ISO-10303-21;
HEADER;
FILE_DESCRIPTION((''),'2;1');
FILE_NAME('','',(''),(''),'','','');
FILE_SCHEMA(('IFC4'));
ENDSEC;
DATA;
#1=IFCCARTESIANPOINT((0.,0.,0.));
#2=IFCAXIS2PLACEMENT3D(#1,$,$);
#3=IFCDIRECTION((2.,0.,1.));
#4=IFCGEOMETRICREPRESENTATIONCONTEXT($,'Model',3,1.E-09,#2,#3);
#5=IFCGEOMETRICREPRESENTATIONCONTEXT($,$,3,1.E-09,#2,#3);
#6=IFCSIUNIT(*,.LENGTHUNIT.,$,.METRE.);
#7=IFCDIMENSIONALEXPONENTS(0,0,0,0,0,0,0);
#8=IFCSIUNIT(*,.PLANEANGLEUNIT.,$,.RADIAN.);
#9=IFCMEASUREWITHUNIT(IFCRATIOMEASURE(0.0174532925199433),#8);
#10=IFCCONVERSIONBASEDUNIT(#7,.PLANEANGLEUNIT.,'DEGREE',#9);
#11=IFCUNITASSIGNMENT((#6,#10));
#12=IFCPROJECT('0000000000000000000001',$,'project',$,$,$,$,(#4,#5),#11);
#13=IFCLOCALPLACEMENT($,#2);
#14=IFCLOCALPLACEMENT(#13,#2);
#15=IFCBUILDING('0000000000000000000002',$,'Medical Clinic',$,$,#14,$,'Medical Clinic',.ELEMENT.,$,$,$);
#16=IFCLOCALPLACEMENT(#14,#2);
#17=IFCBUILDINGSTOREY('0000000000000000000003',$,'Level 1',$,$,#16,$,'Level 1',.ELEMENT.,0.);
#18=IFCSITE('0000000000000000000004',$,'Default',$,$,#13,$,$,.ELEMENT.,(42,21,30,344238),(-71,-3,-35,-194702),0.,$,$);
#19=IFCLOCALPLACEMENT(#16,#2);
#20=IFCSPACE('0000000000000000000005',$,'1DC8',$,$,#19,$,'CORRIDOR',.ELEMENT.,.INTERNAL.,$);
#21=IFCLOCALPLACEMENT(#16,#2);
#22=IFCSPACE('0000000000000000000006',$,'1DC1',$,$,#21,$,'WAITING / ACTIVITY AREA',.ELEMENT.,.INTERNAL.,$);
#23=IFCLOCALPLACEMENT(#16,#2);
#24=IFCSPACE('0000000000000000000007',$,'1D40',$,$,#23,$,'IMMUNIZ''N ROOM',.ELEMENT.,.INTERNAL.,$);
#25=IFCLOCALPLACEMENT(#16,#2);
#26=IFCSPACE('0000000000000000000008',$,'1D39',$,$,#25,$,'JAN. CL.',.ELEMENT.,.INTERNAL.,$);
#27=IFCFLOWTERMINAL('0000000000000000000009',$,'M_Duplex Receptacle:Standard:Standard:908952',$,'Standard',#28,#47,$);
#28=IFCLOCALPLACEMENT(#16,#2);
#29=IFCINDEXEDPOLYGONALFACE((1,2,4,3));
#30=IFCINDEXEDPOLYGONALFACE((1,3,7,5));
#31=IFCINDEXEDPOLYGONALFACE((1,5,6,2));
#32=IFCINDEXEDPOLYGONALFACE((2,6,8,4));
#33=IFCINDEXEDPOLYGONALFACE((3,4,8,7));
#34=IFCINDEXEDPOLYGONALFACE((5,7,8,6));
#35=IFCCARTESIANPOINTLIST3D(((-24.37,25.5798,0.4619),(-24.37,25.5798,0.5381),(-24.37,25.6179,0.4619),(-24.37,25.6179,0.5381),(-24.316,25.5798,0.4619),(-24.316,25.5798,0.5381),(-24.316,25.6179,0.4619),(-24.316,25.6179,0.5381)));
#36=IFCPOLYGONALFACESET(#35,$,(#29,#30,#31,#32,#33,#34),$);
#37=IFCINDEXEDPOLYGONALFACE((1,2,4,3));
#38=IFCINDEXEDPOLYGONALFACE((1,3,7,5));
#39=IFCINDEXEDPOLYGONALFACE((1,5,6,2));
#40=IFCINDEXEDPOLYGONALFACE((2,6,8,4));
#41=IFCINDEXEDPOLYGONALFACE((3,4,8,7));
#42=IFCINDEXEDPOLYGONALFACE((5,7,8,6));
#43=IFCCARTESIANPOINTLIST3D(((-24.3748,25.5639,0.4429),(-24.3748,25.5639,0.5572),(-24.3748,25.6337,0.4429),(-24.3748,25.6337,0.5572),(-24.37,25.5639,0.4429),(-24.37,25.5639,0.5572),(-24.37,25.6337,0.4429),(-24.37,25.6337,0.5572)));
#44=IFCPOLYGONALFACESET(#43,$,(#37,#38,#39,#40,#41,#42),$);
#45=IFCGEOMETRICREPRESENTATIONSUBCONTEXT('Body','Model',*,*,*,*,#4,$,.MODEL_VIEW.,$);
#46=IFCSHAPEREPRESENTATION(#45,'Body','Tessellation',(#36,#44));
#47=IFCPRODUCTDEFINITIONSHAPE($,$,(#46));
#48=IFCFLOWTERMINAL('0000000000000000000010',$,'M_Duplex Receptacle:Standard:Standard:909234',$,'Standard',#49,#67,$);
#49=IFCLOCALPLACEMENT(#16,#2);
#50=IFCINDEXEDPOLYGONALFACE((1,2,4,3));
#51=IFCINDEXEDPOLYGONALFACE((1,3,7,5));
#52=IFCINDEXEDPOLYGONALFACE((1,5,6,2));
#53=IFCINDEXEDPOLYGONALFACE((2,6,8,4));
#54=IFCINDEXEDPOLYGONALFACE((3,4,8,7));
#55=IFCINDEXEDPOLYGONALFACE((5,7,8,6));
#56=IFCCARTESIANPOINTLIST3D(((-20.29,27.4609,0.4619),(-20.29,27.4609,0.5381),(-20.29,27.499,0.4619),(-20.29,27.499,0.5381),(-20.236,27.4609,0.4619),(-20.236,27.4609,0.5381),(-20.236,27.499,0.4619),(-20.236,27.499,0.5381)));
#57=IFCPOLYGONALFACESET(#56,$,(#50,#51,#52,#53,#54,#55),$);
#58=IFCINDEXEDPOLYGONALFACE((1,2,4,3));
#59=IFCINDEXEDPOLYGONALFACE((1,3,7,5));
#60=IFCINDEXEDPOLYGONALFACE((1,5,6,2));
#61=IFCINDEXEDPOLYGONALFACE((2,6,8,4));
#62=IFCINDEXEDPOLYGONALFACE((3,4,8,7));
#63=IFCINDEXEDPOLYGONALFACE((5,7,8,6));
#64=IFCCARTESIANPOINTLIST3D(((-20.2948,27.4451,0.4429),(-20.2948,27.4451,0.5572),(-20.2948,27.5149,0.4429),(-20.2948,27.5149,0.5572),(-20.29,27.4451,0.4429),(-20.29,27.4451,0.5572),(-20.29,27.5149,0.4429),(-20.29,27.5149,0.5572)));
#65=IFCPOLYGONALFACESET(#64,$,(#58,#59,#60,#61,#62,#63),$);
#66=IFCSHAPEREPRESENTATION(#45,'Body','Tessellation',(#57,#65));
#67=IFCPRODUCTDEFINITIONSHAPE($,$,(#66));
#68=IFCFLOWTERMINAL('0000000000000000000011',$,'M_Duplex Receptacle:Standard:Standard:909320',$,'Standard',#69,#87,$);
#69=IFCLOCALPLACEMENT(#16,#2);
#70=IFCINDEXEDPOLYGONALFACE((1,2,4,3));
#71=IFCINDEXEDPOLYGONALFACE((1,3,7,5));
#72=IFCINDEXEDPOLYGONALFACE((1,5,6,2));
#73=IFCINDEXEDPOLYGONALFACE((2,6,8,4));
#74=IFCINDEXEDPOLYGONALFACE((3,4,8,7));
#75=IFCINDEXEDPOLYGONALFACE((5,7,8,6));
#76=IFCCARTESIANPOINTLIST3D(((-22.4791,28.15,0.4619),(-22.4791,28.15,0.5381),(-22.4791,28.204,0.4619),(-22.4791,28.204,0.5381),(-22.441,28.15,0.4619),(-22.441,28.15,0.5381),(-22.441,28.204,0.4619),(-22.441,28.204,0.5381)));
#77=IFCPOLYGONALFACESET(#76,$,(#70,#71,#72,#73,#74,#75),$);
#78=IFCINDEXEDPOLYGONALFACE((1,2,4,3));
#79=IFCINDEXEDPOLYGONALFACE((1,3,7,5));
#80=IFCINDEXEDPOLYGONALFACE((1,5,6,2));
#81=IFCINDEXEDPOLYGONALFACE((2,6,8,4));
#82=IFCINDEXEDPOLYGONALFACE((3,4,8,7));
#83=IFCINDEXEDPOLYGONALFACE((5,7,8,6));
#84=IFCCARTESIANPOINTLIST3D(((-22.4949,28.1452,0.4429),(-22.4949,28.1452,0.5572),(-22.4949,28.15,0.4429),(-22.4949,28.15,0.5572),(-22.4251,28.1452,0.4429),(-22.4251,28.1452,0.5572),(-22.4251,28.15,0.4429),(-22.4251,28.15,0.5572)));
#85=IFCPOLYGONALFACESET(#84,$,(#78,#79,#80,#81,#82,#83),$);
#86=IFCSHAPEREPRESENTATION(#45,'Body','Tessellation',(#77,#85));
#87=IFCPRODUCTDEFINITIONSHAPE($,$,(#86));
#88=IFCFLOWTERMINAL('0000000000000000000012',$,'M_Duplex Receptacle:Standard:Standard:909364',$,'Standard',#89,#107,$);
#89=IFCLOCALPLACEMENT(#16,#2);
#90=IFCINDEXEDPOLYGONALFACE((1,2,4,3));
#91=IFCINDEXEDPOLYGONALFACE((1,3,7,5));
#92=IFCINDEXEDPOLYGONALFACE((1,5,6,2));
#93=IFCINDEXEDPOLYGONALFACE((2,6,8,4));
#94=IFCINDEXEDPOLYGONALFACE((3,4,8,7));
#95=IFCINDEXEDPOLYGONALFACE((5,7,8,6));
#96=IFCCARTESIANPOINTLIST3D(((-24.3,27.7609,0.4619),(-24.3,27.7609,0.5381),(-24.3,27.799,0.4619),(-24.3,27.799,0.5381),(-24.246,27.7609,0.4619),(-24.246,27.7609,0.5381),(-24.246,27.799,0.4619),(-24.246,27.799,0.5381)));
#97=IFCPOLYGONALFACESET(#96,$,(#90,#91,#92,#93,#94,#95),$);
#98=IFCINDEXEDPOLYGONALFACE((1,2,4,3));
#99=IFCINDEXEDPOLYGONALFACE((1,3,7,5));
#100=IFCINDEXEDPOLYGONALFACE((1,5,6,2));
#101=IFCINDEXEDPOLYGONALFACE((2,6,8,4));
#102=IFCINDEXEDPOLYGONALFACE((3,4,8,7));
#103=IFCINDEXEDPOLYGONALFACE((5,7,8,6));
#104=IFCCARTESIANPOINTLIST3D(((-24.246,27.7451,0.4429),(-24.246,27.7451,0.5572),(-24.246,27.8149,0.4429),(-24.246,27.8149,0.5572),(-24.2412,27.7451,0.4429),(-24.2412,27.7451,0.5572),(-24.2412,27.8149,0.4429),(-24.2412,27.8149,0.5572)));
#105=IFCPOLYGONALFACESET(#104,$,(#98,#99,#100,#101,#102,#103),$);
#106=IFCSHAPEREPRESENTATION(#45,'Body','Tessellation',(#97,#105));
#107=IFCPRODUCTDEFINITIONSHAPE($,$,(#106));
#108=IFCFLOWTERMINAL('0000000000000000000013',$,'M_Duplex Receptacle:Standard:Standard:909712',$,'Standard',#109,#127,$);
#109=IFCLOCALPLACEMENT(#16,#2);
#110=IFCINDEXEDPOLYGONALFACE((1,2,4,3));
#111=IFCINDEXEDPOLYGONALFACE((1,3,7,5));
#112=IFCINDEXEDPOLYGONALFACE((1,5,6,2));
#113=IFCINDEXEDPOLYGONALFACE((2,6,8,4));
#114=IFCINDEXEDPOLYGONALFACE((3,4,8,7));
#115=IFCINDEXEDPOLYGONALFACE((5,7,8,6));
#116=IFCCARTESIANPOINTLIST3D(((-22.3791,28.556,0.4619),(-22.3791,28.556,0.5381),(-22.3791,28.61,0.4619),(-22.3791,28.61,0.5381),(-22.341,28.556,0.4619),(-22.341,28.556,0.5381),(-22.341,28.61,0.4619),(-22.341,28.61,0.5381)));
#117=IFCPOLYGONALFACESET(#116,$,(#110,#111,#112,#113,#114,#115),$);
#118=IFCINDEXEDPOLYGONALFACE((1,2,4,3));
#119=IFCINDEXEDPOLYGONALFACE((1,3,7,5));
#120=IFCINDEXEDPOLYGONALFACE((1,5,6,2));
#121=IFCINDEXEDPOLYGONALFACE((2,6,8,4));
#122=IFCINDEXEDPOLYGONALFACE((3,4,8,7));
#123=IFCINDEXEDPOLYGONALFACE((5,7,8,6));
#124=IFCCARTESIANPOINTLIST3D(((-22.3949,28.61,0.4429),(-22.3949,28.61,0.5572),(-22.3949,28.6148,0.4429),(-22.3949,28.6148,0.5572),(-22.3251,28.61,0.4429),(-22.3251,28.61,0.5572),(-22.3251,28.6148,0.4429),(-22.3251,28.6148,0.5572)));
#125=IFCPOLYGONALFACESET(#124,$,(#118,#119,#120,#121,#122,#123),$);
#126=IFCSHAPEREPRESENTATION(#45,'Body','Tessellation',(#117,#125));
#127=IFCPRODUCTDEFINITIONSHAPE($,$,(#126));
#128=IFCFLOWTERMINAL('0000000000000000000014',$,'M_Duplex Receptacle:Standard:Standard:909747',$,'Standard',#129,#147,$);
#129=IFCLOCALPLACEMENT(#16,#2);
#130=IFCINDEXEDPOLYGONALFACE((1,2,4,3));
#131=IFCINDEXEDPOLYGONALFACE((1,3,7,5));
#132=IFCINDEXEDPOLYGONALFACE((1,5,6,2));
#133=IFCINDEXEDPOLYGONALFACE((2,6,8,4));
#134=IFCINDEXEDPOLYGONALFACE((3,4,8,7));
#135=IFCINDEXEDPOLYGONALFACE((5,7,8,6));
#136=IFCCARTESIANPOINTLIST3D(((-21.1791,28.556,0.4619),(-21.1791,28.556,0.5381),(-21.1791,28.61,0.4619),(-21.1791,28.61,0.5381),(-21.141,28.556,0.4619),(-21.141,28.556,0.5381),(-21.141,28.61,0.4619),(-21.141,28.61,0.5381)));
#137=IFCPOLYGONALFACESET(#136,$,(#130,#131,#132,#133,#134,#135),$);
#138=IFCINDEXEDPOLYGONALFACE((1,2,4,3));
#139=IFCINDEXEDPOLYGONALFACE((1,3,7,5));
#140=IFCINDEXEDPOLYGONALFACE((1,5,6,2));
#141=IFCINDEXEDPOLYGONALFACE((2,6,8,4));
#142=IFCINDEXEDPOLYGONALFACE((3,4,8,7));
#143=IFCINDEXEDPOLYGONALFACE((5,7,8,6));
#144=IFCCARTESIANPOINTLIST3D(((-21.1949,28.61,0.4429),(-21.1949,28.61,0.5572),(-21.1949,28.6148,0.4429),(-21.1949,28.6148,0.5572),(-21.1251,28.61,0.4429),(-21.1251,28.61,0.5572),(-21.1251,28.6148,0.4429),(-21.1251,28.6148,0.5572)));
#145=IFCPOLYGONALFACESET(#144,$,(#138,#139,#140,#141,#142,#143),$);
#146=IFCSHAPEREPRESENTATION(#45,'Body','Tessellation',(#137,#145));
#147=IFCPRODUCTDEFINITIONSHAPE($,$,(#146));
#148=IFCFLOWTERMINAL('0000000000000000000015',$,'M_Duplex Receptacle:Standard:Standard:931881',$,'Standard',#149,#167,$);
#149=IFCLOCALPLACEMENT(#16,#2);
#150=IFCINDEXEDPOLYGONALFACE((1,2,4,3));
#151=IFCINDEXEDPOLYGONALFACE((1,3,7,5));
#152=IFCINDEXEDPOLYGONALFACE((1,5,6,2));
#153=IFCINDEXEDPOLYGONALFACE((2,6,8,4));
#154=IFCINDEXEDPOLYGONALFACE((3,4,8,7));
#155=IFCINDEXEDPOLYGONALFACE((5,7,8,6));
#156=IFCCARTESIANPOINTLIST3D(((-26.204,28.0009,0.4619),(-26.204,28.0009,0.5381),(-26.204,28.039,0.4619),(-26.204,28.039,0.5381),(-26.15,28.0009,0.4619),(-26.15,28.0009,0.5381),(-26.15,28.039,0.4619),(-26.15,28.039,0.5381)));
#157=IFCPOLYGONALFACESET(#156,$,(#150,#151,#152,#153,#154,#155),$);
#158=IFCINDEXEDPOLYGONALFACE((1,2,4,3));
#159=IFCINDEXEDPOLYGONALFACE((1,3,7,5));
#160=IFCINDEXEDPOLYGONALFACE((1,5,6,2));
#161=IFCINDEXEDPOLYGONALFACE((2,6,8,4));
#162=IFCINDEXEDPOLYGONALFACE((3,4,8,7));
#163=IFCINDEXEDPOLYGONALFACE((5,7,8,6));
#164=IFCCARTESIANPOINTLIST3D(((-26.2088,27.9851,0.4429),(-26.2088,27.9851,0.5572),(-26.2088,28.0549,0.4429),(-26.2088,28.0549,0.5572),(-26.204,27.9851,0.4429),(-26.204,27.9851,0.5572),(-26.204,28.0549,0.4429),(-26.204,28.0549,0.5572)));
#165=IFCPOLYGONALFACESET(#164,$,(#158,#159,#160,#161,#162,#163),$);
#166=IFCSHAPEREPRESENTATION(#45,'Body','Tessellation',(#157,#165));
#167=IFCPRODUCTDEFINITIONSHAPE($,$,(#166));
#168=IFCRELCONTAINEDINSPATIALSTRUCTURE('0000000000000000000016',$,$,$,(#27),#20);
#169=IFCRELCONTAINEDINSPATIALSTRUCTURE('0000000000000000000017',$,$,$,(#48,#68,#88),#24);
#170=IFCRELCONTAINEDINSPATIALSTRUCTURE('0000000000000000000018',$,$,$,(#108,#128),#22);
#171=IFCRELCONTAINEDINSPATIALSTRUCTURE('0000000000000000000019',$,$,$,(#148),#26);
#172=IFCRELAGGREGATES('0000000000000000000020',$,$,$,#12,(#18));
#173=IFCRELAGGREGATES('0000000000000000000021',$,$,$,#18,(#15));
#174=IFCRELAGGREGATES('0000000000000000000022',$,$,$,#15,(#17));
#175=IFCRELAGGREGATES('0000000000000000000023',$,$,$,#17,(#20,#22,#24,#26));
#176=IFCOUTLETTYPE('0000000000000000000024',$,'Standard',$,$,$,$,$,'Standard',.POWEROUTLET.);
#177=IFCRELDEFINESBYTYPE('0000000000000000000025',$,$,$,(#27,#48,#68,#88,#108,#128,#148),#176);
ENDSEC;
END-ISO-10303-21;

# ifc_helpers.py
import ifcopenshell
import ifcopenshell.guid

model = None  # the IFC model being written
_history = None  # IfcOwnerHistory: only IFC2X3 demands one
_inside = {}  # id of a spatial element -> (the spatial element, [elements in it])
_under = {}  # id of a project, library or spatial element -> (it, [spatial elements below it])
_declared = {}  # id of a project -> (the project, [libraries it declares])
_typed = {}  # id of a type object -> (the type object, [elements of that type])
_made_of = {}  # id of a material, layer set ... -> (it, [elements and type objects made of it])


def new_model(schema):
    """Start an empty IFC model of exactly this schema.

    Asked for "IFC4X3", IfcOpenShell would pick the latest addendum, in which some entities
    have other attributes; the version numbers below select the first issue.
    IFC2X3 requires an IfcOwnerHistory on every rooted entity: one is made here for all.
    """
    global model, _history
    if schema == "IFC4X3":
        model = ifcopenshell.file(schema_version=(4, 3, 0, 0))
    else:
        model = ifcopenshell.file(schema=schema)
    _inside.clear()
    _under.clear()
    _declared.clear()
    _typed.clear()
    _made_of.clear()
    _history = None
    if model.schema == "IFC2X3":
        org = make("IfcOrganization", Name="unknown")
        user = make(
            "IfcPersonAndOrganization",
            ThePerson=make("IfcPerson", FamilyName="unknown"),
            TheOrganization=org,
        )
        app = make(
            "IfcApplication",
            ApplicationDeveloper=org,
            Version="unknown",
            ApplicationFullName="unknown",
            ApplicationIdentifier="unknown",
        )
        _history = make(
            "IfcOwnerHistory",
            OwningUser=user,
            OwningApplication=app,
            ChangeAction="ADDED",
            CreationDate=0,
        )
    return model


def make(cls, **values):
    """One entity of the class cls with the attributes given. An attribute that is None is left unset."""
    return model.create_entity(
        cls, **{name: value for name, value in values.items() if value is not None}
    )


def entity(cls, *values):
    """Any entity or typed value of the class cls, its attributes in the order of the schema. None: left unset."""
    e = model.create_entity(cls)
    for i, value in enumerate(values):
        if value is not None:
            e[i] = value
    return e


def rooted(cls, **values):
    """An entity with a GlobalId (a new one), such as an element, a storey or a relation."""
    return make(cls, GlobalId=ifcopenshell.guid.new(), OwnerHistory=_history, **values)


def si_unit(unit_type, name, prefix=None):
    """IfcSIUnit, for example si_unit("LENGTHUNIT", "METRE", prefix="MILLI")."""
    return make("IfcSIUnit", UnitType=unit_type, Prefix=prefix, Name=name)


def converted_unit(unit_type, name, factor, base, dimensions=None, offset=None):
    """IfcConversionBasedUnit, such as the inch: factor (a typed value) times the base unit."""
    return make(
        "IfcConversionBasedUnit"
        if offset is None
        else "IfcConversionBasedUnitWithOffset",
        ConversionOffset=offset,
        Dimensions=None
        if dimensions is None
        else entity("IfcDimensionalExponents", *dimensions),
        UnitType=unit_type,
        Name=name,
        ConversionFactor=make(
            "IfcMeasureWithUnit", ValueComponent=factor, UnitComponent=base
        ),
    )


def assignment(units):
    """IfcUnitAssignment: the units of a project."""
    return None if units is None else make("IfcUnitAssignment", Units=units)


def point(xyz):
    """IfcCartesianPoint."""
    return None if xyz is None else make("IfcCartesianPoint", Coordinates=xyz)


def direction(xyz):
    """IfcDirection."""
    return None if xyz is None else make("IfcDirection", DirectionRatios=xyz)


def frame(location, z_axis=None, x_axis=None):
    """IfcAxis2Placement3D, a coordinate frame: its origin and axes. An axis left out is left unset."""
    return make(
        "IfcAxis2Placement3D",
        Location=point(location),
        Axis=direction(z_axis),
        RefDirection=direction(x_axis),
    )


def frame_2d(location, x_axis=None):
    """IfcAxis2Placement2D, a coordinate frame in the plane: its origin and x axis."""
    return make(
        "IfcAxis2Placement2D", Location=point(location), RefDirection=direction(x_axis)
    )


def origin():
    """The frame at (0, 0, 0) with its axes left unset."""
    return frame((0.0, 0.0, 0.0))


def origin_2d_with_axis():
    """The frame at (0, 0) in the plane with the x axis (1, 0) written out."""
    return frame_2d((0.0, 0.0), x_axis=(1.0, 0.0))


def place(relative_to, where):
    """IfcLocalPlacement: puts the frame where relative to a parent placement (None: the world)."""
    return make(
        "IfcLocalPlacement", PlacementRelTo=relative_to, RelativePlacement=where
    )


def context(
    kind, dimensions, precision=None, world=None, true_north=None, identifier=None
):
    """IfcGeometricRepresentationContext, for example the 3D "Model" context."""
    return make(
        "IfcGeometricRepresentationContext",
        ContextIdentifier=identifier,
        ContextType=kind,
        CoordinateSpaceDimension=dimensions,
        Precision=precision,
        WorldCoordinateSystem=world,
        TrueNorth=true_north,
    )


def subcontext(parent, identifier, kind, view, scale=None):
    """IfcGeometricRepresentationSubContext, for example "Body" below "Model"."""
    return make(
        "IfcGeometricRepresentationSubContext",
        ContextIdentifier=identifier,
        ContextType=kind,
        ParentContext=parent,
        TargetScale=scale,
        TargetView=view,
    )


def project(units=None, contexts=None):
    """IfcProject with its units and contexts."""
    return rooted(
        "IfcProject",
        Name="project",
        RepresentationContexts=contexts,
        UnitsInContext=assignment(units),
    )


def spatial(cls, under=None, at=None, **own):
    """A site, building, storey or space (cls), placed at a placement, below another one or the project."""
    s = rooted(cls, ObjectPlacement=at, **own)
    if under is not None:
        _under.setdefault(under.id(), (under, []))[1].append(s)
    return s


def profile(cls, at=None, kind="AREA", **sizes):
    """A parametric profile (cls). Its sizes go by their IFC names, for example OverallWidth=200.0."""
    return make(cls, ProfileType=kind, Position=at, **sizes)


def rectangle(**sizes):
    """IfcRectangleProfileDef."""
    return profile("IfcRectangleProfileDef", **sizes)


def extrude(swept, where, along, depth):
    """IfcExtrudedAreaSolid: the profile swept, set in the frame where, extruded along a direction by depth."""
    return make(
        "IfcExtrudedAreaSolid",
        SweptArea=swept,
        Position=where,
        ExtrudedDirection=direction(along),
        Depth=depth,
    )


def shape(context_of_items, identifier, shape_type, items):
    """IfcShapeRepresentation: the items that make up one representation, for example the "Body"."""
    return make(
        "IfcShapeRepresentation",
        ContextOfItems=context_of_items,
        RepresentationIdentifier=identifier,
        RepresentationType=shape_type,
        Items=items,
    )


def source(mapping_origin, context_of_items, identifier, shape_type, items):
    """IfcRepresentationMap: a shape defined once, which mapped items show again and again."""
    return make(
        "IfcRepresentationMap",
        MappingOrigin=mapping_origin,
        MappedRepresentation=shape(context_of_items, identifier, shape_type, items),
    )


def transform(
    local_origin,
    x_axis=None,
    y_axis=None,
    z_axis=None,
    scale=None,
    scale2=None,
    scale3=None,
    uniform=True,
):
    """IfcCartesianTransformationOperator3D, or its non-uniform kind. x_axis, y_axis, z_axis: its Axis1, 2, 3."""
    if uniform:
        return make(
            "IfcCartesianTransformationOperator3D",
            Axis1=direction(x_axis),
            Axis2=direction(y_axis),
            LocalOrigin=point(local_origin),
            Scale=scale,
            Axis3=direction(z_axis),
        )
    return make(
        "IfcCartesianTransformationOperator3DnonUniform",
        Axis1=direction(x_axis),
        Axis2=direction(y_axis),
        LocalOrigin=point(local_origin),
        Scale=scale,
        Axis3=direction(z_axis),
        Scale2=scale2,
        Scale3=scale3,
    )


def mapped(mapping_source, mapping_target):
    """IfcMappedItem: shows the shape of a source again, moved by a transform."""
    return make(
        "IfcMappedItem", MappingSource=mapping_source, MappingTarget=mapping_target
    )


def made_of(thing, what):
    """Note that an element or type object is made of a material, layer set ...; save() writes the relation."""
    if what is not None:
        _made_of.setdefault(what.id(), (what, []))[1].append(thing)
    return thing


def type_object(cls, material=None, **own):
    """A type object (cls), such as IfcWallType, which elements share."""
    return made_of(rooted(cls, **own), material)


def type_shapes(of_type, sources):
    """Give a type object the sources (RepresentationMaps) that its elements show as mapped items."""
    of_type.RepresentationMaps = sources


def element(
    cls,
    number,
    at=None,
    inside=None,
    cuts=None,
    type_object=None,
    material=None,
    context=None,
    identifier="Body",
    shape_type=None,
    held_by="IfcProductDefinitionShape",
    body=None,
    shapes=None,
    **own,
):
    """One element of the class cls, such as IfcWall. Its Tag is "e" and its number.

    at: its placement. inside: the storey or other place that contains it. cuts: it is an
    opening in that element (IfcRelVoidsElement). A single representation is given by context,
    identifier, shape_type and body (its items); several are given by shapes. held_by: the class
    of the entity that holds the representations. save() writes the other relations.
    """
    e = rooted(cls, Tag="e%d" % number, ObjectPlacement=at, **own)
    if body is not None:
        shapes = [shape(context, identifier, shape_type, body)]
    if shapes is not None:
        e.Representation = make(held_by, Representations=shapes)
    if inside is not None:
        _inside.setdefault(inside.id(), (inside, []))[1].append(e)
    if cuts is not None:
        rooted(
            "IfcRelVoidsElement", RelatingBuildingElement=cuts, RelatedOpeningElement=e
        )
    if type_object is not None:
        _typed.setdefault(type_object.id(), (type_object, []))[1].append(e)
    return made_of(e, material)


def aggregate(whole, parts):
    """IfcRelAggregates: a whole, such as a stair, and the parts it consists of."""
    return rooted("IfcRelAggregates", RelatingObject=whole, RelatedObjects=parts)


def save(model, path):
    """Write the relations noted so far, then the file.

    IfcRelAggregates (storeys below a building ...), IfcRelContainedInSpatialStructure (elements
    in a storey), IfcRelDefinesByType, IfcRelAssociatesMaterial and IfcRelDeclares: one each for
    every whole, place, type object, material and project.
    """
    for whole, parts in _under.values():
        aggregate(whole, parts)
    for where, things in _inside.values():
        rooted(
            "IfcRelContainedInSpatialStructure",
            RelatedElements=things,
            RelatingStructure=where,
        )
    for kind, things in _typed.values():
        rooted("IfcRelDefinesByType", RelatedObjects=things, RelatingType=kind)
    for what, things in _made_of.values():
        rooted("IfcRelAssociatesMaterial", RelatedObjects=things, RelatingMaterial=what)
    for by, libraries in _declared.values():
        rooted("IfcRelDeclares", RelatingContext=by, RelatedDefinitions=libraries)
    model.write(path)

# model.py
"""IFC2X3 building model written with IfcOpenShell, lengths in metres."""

from ifc_helpers import new_model, entity, si_unit, converted_unit, direction, frame, frame_2d, origin, origin_2d_with_axis, place, context, subcontext, project, spatial, rectangle, extrude, source, transform, mapped, type_object, type_shapes, element, save


model = new_model("IFC2X3")

# Units and contexts
model_context = context("Model", 3, precision=1e-09, world=origin(), true_north=direction((2.0, 0.0, 1.0)))
context_of_model = context(None, 3, precision=1e-09, world=origin(), true_north=direction((2.0, 0.0, 1.0)))
body_context = subcontext(model_context, "Body", "Model", "MODEL_VIEW")
ifc_project = project(units=[si_unit("LENGTHUNIT", "METRE"), converted_unit("PLANEANGLEUNIT", "DEGREE", entity("IfcRatioMeasure", 0.0174532925199433), si_unit("PLANEANGLEUNIT", "RADIAN"), dimensions=[0, 0, 0, 0, 0, 0, 0])], contexts=[model_context, context_of_model])

# Site, building, storey
site_placement = place(None, origin())
site = spatial("IfcSite", under=ifc_project, at=site_placement, Name="Default", CompositionType="ELEMENT", RefLatitude=(42, 21, 30, 344238), RefLongitude=(-71, -3, -35, -194702), RefElevation=0.0)
building_placement = place(site_placement, origin())
building = spatial("IfcBuilding", under=site, at=building_placement, Name="Medical Clinic", LongName="Medical Clinic", CompositionType="ELEMENT")
storey_placement = place(building_placement, origin())
storey = spatial("IfcBuildingStorey", under=building, at=storey_placement, Name="Level 1", LongName="Level 1", CompositionType="ELEMENT", Elevation=0.0)

# Shared definitions
space_1_placement = place(storey_placement, origin())
space_1 = spatial("IfcSpace", under=storey, at=space_1_placement, Name="1DC8", LongName="CORRIDOR", CompositionType="ELEMENT", InteriorOrExteriorSpace="INTERNAL")

# Shared definitions
space_2_placement = place(storey_placement, origin())
space_2 = spatial("IfcSpace", under=storey, at=space_2_placement, Name="1DC1", LongName="WAITING / ACTIVITY AREA", CompositionType="ELEMENT", InteriorOrExteriorSpace="INTERNAL")

# Shared definitions
space_3_placement = place(storey_placement, origin())
space_3 = spatial("IfcSpace", under=storey, at=space_3_placement, Name="1D40", LongName="IMMUNIZ'N ROOM", CompositionType="ELEMENT", InteriorOrExteriorSpace="INTERNAL")

# Shared definitions
outlet_type = type_object("IfcOutletType", Name="Standard", ElementType="Standard", PredefinedType="POWEROUTLET")
shared_shape_1 = source(origin(), body_context, "Body", "SweptSolid", [
    extrude(rectangle(XDim=0.0381, YDim=0.0762, at=origin_2d_with_axis()), frame((0.0, 0.0, -0.054), z_axis=(0.0, 0.0, 1.0), x_axis=(-1.0, 0.0, 0.0)), (0.0, 0.0, 1.0), 0.054),
    extrude(rectangle(XDim=0.0698, YDim=0.1143, at=frame_2d((0.0, 0.0), x_axis=(1.0, 0.0))), frame((0.0, 0.0, 0.0), z_axis=(0.0, 0.0, 1.0), x_axis=(-1.0, 0.0, 0.0)), (0.0, 0.0, 1.0), 0.0048),
])
type_shapes(outlet_type, [shared_shape_1])

# Flow terminals
flow_terminal_1_placement = place(space_1_placement, frame((-24.37, 25.5988, 0.5), z_axis=(-1.0, 0.0, 0.0), x_axis=(0.0, -1.0, 0.0)))
element("IfcFlowTerminal", 1, at=flow_terminal_1_placement, inside=space_1, type_object=outlet_type, Name="M_Duplex Receptacle:Standard:Standard:908952", ObjectType="Standard", context=body_context, shape_type="MappedRepresentation", body=[
    mapped(shared_shape_1, transform((0.0, 0.0, 0.0), scale=1.0)),
])
for number, where, z_axis, x_axis, name in (
    (2, (-20.29, 27.48, 0.5), (-1.0, 0.0, 0.0), (0.0, -1.0, 0.0), "M_Duplex Receptacle:Standard:Standard:909234"),
    (3, (-22.46, 28.15, 0.5), (0.0, -1.0, 0.0), (1.0, 0.0, 0.0), "M_Duplex Receptacle:Standard:Standard:909320"),
    (4, (-24.246, 27.78, 0.5), (1.0, 0.0, 0.0), (0.0, 1.0, 0.0), "M_Duplex Receptacle:Standard:Standard:909364"),
):
    element("IfcFlowTerminal", number, at=place(space_3_placement, frame(where, z_axis=z_axis, x_axis=x_axis)), inside=space_3, type_object=outlet_type, Name=name, ObjectType="Standard", context=body_context, shape_type="MappedRepresentation", body=[
        mapped(shared_shape_1, transform((0.0, 0.0, 0.0), scale=1.0)),
    ])
for number, where, z_axis, x_axis, name in (
    (5, (-22.36, 28.61, 0.5), (0.0, 1.0, 0.0), (-1.0, 0.0, 0.0), "M_Duplex Receptacle:Standard:Standard:909712"),
    (6, (-21.16, 28.61, 0.5), (0.0, 1.0, 0.0), (-1.0, 0.0, 0.0), "M_Duplex Receptacle:Standard:Standard:909747"),
):
    element("IfcFlowTerminal", number, at=place(space_2_placement, frame(where, z_axis=z_axis, x_axis=x_axis)), inside=space_2, type_object=outlet_type, Name=name, ObjectType="Standard", context=body_context, shape_type="MappedRepresentation", body=[
        mapped(shared_shape_1, transform((0.0, 0.0, 0.0), scale=1.0)),
    ])

# Shared definitions
space_4_placement = place(storey_placement, origin())
space_4 = spatial("IfcSpace", under=storey, at=space_4_placement, Name="1D39", LongName="JAN. CL.", CompositionType="ELEMENT", InteriorOrExteriorSpace="INTERNAL")

# Flow terminal
flow_terminal_2_placement = place(space_4_placement, frame((-26.204, 28.02, 0.5), z_axis=(-1.0, 0.0, 0.0), x_axis=(0.0, -1.0, 0.0)))
element("IfcFlowTerminal", 7, at=flow_terminal_2_placement, inside=space_4, type_object=outlet_type, Name="M_Duplex Receptacle:Standard:Standard:931881", ObjectType="Standard", context=body_context, shape_type="MappedRepresentation", body=[
    mapped(shared_shape_1, transform((0.0, 0.0, 0.0), scale=1.0)),
])

save(model, "model.ifc")
